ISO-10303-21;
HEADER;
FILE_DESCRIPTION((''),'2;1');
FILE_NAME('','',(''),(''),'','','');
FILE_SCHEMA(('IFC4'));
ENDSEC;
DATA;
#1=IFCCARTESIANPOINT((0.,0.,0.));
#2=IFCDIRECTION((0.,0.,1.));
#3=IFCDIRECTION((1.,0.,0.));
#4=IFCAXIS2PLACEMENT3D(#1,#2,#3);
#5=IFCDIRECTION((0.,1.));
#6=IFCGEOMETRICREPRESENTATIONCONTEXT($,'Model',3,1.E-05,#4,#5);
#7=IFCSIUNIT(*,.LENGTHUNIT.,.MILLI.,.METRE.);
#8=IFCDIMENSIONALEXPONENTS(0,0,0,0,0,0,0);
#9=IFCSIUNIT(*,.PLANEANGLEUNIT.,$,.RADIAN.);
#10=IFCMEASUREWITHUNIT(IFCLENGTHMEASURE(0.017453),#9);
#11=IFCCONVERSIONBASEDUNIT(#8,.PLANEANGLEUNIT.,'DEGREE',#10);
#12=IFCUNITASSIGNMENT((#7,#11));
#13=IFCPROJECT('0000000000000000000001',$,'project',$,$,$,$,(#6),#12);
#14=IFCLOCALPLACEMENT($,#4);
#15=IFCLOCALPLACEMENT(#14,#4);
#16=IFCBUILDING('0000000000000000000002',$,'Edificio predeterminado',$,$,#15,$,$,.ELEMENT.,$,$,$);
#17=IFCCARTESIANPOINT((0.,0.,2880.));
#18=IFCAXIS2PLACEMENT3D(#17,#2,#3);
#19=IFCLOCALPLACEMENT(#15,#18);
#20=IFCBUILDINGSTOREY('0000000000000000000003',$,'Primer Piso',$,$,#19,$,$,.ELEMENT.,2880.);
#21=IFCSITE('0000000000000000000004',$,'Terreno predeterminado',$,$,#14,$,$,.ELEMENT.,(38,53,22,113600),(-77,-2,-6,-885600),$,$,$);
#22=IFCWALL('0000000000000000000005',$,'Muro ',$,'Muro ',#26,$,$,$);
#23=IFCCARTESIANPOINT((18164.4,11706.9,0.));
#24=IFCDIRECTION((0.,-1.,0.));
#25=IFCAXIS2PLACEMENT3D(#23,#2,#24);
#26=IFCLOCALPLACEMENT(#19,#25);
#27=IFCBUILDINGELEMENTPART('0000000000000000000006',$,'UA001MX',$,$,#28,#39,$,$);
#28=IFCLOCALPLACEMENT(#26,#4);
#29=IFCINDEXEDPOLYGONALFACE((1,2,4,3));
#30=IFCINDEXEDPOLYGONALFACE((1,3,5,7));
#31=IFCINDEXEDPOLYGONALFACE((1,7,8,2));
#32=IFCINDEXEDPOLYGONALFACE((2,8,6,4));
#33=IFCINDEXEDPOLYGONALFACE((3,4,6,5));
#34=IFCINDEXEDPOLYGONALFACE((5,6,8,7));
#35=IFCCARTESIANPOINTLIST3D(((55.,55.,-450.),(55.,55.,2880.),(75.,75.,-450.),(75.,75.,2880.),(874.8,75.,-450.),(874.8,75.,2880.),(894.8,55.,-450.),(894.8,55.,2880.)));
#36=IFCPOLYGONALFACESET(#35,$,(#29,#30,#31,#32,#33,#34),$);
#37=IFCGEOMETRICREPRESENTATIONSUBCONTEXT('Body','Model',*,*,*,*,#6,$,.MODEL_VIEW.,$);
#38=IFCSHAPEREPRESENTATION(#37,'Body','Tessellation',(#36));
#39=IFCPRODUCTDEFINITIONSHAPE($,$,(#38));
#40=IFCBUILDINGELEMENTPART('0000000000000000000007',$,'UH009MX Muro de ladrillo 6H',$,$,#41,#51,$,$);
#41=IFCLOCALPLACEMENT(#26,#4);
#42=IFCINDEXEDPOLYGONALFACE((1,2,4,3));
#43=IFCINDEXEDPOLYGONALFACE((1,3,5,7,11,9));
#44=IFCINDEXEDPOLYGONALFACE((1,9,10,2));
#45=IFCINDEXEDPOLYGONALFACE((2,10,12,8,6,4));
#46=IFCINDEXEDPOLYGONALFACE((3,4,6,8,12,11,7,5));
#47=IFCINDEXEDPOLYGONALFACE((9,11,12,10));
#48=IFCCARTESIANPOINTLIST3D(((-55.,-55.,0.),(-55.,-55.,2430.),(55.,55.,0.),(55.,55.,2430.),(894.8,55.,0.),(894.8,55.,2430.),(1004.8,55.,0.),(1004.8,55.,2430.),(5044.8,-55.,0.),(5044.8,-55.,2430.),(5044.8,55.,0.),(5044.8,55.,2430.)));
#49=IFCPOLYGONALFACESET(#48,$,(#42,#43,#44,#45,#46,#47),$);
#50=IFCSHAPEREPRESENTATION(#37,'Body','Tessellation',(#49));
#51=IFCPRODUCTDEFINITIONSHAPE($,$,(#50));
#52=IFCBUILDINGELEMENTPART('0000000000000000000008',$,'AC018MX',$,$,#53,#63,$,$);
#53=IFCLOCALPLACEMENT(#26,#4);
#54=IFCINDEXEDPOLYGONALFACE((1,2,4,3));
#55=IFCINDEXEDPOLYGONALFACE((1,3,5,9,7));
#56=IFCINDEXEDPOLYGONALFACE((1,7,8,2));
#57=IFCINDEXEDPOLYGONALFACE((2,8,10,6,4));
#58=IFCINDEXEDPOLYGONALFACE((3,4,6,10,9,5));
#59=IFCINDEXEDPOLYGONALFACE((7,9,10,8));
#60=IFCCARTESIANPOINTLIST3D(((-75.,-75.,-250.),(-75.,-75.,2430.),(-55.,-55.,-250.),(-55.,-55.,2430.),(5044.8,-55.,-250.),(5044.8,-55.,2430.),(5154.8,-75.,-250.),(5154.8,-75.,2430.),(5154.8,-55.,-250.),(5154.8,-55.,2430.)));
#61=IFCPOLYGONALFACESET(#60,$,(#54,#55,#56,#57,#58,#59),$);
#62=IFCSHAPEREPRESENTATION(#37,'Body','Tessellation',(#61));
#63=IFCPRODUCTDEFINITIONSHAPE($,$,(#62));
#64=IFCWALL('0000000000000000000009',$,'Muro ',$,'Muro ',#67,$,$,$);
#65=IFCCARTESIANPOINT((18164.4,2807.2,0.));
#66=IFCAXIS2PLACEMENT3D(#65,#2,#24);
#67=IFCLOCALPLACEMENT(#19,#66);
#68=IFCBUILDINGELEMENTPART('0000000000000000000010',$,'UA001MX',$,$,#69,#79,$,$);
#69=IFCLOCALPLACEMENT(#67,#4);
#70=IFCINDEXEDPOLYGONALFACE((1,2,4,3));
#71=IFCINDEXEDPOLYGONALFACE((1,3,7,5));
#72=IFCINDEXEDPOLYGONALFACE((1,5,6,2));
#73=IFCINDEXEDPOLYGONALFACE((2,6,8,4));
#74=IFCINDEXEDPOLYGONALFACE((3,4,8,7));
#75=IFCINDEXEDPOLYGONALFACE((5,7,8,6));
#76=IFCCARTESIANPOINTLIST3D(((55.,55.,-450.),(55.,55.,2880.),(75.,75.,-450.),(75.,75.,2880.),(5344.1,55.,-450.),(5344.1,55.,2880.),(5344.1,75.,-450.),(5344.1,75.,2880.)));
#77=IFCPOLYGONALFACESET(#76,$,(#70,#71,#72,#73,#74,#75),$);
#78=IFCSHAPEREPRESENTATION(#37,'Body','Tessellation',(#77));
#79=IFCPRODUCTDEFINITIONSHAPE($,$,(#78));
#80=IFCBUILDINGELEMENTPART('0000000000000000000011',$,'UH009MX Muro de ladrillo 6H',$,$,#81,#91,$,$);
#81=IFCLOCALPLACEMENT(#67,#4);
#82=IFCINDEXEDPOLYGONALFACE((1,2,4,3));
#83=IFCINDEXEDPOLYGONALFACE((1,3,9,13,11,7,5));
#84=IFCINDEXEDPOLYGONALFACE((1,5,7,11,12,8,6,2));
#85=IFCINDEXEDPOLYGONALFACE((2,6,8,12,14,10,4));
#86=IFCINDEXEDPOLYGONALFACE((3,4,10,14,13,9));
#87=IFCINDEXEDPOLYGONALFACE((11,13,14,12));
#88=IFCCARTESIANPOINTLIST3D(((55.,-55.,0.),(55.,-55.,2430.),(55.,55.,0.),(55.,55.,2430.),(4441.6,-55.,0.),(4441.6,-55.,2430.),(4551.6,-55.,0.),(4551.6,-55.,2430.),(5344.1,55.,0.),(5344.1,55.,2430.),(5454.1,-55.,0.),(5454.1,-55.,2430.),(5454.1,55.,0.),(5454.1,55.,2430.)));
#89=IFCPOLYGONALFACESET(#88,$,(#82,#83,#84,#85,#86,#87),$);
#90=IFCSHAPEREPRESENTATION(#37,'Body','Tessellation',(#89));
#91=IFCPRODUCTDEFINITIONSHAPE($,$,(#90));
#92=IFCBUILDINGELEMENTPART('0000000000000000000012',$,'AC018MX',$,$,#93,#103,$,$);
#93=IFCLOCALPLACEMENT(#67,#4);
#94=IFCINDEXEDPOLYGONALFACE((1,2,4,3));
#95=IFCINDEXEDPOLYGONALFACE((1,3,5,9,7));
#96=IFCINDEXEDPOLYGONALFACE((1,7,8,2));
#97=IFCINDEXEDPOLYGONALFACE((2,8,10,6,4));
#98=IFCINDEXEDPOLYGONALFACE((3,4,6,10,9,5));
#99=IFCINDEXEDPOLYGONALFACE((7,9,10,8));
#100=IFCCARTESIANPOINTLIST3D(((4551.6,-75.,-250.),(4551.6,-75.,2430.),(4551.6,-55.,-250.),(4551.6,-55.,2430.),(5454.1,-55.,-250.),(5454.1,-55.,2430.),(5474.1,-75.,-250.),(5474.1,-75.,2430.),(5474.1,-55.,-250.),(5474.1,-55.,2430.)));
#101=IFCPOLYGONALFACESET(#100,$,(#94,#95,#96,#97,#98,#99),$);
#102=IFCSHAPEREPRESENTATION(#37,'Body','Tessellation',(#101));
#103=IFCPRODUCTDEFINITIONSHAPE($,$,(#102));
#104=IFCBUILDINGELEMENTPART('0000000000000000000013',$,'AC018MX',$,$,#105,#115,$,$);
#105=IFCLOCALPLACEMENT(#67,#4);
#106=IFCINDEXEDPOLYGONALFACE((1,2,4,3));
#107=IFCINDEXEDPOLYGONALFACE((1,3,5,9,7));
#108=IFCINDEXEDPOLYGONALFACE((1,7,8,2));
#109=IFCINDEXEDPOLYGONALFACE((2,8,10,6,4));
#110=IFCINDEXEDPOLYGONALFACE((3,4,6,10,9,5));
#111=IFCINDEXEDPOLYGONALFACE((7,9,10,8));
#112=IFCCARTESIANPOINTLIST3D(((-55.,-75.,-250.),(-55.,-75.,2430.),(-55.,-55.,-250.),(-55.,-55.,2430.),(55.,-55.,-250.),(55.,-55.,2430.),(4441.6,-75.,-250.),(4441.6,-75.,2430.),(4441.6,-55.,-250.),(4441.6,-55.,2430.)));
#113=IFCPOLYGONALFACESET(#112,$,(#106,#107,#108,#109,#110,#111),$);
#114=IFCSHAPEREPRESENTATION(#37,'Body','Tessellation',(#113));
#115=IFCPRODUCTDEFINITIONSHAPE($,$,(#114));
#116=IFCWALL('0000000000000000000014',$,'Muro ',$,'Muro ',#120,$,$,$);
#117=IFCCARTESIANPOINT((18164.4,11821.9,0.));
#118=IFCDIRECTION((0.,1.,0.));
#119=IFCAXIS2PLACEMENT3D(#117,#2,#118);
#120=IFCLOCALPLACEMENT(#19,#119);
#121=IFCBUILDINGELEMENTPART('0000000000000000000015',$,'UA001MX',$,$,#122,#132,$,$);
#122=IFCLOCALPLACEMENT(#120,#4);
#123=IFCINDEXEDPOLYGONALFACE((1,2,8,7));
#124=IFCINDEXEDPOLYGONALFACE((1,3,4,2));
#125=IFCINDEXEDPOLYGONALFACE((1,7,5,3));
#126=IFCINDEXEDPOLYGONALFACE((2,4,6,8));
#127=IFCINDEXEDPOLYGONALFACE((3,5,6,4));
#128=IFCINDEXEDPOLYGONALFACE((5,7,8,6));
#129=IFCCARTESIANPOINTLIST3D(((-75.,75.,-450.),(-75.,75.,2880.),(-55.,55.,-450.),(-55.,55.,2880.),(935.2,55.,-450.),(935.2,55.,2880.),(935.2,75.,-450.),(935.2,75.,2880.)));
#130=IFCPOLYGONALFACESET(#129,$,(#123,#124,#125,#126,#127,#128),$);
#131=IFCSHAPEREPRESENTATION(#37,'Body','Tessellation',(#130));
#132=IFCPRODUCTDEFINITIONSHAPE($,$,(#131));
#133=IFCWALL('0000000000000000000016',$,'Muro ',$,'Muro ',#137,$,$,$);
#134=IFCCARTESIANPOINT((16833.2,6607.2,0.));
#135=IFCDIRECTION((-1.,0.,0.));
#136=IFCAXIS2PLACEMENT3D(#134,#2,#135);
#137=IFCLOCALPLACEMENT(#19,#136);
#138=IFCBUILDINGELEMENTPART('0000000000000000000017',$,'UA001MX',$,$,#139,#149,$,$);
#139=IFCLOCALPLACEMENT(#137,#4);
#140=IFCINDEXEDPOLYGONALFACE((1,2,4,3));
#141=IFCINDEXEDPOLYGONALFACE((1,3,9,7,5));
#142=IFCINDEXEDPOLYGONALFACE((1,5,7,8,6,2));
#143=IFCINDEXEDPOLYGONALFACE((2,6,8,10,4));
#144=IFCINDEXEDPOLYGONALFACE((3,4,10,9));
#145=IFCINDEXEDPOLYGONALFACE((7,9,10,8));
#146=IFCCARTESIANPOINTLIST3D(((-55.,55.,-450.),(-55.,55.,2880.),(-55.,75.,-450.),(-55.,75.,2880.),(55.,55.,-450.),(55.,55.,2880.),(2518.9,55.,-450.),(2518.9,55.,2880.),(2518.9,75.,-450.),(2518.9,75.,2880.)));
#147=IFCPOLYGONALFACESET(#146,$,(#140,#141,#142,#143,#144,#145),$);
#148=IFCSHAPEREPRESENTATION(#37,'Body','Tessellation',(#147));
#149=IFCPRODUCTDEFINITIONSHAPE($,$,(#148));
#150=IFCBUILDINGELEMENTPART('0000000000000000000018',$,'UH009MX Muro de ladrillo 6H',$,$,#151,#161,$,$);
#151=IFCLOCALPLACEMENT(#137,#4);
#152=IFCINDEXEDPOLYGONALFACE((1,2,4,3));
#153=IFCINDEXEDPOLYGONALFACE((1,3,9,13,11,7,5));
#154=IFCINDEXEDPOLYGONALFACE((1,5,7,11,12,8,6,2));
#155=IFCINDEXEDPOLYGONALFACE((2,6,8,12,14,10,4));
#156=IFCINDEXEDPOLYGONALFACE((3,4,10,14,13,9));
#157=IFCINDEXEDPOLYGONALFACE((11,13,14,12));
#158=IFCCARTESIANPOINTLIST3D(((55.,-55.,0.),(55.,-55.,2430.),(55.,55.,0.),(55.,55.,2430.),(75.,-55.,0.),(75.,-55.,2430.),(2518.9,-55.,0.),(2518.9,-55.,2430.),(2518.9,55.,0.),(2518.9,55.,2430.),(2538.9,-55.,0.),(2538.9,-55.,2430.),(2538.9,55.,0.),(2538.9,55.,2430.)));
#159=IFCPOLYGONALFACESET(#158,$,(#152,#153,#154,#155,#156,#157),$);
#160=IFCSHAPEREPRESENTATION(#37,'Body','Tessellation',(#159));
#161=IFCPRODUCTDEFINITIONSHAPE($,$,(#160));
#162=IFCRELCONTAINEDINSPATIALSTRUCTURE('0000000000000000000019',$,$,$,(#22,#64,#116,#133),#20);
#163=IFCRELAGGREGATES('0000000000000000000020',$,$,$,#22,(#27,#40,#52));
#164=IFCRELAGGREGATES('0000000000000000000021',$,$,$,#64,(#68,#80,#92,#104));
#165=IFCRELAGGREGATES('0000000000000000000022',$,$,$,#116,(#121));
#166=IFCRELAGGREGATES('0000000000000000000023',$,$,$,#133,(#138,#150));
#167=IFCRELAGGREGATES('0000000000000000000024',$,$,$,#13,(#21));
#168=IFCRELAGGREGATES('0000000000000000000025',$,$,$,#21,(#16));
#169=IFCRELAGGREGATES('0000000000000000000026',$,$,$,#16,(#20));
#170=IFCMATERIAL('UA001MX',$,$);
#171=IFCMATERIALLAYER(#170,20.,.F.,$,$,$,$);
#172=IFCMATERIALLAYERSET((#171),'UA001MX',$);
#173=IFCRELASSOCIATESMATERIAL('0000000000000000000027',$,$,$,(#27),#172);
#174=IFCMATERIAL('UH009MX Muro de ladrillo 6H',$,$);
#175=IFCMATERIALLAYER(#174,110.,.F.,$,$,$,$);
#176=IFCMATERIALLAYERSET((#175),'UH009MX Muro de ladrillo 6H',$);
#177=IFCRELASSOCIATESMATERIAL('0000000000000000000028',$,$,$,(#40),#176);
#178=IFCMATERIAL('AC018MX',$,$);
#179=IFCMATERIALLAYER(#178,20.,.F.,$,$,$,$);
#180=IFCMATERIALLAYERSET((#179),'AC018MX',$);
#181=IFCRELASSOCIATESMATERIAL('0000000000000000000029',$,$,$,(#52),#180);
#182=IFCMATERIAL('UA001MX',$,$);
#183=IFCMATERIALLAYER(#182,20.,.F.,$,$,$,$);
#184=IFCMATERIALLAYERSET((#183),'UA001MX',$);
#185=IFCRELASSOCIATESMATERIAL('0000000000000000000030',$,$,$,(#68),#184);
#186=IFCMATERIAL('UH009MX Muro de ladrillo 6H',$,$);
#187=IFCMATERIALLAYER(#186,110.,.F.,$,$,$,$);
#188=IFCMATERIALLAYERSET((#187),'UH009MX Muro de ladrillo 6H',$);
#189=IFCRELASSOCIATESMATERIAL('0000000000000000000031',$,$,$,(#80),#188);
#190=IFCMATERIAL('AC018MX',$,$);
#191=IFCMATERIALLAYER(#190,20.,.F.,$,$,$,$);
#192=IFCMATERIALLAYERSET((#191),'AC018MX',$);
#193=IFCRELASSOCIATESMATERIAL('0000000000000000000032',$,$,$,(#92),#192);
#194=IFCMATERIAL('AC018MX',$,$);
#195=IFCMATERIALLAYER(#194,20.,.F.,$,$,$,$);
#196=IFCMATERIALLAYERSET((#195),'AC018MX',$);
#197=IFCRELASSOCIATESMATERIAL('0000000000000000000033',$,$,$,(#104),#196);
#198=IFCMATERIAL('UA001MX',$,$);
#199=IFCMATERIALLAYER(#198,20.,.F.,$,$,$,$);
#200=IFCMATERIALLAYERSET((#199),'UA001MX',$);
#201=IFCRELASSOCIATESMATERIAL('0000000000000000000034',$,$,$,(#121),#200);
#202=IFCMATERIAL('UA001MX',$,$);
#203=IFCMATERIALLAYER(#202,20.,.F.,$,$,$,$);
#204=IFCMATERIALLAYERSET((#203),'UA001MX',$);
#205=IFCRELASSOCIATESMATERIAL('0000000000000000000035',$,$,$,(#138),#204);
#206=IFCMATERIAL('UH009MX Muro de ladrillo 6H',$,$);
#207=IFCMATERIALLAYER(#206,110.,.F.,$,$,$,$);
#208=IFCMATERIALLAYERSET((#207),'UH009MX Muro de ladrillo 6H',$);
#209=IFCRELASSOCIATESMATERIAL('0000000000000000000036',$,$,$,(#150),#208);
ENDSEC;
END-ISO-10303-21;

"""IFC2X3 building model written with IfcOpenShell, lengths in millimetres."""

from ifc_helpers import new_model, entity, si_unit, converted_unit, direction, frame, origin_with_axes, place, context, subcontext, project, spatial, polyline, outline, extrude, material, layer, layer_set, layer_usage, element, aggregate, save


model = new_model("IFC2X3")

# Units and contexts
model_context = context("Model", 3, precision=1e-05, world=origin_with_axes(), true_north=direction((0.0, 1.0)))
body_context = subcontext(model_context, "Body", "Model", "MODEL_VIEW")
ifc_project = project(units=[si_unit("LENGTHUNIT", "METRE", prefix="MILLI"), converted_unit("PLANEANGLEUNIT", "DEGREE", entity("IfcLengthMeasure", 0.017453), si_unit("PLANEANGLEUNIT", "RADIAN"), dimensions=[0, 0, 0, 0, 0, 0, 0])], contexts=[model_context])

# Site, building, storey
site_placement = place(None, origin_with_axes())
site = spatial("IfcSite", under=ifc_project, at=site_placement, Name="Terreno predeterminado", CompositionType="ELEMENT", RefLatitude=(38, 53, 22, 113600), RefLongitude=(-77, -2, -6, -885600))
building_placement = place(site_placement, origin_with_axes())
building = spatial("IfcBuilding", under=site, at=building_placement, Name="Edificio predeterminado", CompositionType="ELEMENT")
storey_placement = place(building_placement, frame((0.0, 0.0, 2880.0), z_axis=(0.0, 0.0, 1.0), x_axis=(1.0, 0.0, 0.0)))
storey = spatial("IfcBuildingStorey", under=building, at=storey_placement, Name="Primer Piso", CompositionType="ELEMENT", Elevation=2880.0)

# Walls, building element parts
wall_1_placement = place(storey_placement, frame((18164.4, 11706.9, 0.0), z_axis=(0.0, 0.0, 1.0), x_axis=(0.0, -1.0, 0.0)))
wall_1 = element("IfcWall", 1, at=wall_1_placement, inside=storey, Name="Muro ", ObjectType="Muro ")
ifc_material_1 = material(Name="UA001MX")
ifc_layer_1 = layer(ifc_material_1, 20.0, ventilated=False)
ifc_layer_set_1 = layer_set([ifc_layer_1], Name="UA001MX")
ifc_layer_usage_1 = layer_usage(ifc_layer_set_1, "AXIS2", "NEGATIVE", -75.0)
building_element_part_1_placement = place(wall_1_placement, origin_with_axes())
building_element_part_1 = element("IfcBuildingElementPart", 2, at=building_element_part_1_placement, material=ifc_layer_usage_1, Name="UA001MX", context=body_context, shape_type="SweptSolid", body=[
    extrude(outline(polyline([(874.8, 75.0), (894.8, 55.0), (55.0, 55.0), (75.0, 75.0), (874.8, 75.0)])), frame((0.0, 0.0, -450.0), z_axis=(0.0, 0.0, 1.0), x_axis=(1.0, 0.0, 0.0)), (0.0, 0.0, 1.0), 3330.0),
])
ifc_material_2 = material(Name="UH009MX Muro de ladrillo 6H")
ifc_layer_2 = layer(ifc_material_2, 110.0, ventilated=False)
ifc_layer_set_2 = layer_set([ifc_layer_2], Name="UH009MX Muro de ladrillo 6H")
ifc_layer_usage_2 = layer_usage(ifc_layer_set_2, "AXIS2", "NEGATIVE", -55.0)
building_element_part_2_placement = place(wall_1_placement, origin_with_axes())
building_element_part_2 = element("IfcBuildingElementPart", 3, at=building_element_part_2_placement, material=ifc_layer_usage_2, Name="UH009MX Muro de ladrillo 6H", context=body_context, shape_type="SweptSolid", body=[
    extrude(outline(polyline([(5044.8, 55.0), (5044.8, -55.0), (-55.0, -55.0), (55.0, 55.0), (894.8, 55.0), (1004.8, 55.0), (5044.8, 55.0)])), origin_with_axes(), (0.0, 0.0, 1.0), 2430.0),
])
ifc_material_3 = material(Name="AC018MX")
ifc_layer_3 = layer(ifc_material_3, 20.0, ventilated=False)
ifc_layer_set_3 = layer_set([ifc_layer_3], Name="AC018MX")
ifc_layer_usage_3 = layer_usage(ifc_layer_set_3, "AXIS2", "NEGATIVE", 55.0)
building_element_part_3_placement = place(wall_1_placement, origin_with_axes())
building_element_part_3 = element("IfcBuildingElementPart", 4, at=building_element_part_3_placement, material=ifc_layer_usage_3, Name="AC018MX", context=body_context, shape_type="SweptSolid", body=[
    extrude(outline(polyline([(5154.8, -55.0), (5154.8, -75.0), (-75.0, -75.0), (-55.0, -55.0), (5044.8, -55.0), (5154.8, -55.0)])), frame((0.0, 0.0, -250.0), z_axis=(0.0, 0.0, 1.0), x_axis=(1.0, 0.0, 0.0)), (0.0, 0.0, 1.0), 2680.0),
])
aggregate(wall_1, [building_element_part_1, building_element_part_2, building_element_part_3])
wall_2_placement = place(storey_placement, frame((18164.4, 2807.2, 0.0), z_axis=(0.0, 0.0, 1.0), x_axis=(0.0, -1.0, 0.0)))
wall_2 = element("IfcWall", 5, at=wall_2_placement, inside=storey, Name="Muro ", ObjectType="Muro ")
ifc_material_4 = material(Name="UA001MX")
ifc_layer_4 = layer(ifc_material_4, 20.0, ventilated=False)
ifc_layer_set_4 = layer_set([ifc_layer_4], Name="UA001MX")
ifc_layer_usage_4 = layer_usage(ifc_layer_set_4, "AXIS2", "NEGATIVE", -75.0)
building_element_part_4_placement = place(wall_2_placement, origin_with_axes())
building_element_part_4 = element("IfcBuildingElementPart", 6, at=building_element_part_4_placement, material=ifc_layer_usage_4, Name="UA001MX", context=body_context, shape_type="SweptSolid", body=[
    extrude(outline(polyline([(5344.1, 75.0), (5344.1, 55.0), (55.0, 55.0), (75.0, 75.0), (5344.1, 75.0)])), frame((0.0, 0.0, -450.0), z_axis=(0.0, 0.0, 1.0), x_axis=(1.0, 0.0, 0.0)), (0.0, 0.0, 1.0), 3330.0),
])
ifc_material_5 = material(Name="UH009MX Muro de ladrillo 6H")
ifc_layer_5 = layer(ifc_material_5, 110.0, ventilated=False)
ifc_layer_set_5 = layer_set([ifc_layer_5], Name="UH009MX Muro de ladrillo 6H")
ifc_layer_usage_5 = layer_usage(ifc_layer_set_5, "AXIS2", "NEGATIVE", -55.0)
building_element_part_5_placement = place(wall_2_placement, origin_with_axes())
building_element_part_5 = element("IfcBuildingElementPart", 7, at=building_element_part_5_placement, material=ifc_layer_usage_5, Name="UH009MX Muro de ladrillo 6H", context=body_context, shape_type="SweptSolid", body=[
    extrude(outline(polyline([(5454.1, 55.0), (5454.1, -55.0), (4551.6, -55.0), (4441.6, -55.0), (55.0, -55.0), (55.0, 55.0), (5344.1, 55.0), (5454.1, 55.0)])), origin_with_axes(), (0.0, 0.0, 1.0), 2430.0),
])
ifc_material_6 = material(Name="AC018MX")
ifc_layer_6 = layer(ifc_material_6, 20.0, ventilated=False)
ifc_layer_set_6 = layer_set([ifc_layer_6], Name="AC018MX")
ifc_layer_usage_6 = layer_usage(ifc_layer_set_6, "AXIS2", "NEGATIVE", 55.0)
building_element_part_6_placement = place(wall_2_placement, origin_with_axes())
building_element_part_6 = element("IfcBuildingElementPart", 8, at=building_element_part_6_placement, material=ifc_layer_usage_6, Name="AC018MX", context=body_context, shape_type="SweptSolid", body=[
    extrude(outline(polyline([(5474.1, -55.0), (5474.1, -75.0), (4551.6, -75.0), (4551.6, -55.0), (5454.1, -55.0), (5474.1, -55.0)])), frame((0.0, 0.0, -250.0), z_axis=(0.0, 0.0, 1.0), x_axis=(1.0, 0.0, 0.0)), (0.0, 0.0, 1.0), 2680.0),
])
ifc_material_7 = material(Name="AC018MX")
ifc_layer_7 = layer(ifc_material_7, 20.0, ventilated=False)
ifc_layer_set_7 = layer_set([ifc_layer_7], Name="AC018MX")
ifc_layer_usage_7 = layer_usage(ifc_layer_set_7, "AXIS2", "NEGATIVE", 55.0)
building_element_part_7_placement = place(wall_2_placement, origin_with_axes())
building_element_part_7 = element("IfcBuildingElementPart", 9, at=building_element_part_7_placement, material=ifc_layer_usage_7, Name="AC018MX", context=body_context, shape_type="SweptSolid", body=[
    extrude(outline(polyline([(4441.6, -55.0), (4441.6, -75.0), (-55.0, -75.0), (-55.0, -55.0), (55.0, -55.0), (4441.6, -55.0)])), frame((0.0, 0.0, -250.0), z_axis=(0.0, 0.0, 1.0), x_axis=(1.0, 0.0, 0.0)), (0.0, 0.0, 1.0), 2680.0),
])
aggregate(wall_2, [building_element_part_4, building_element_part_5, building_element_part_6, building_element_part_7])

# Wall, building element part
wall_3_placement = place(storey_placement, frame((18164.4, 11821.9, 0.0), z_axis=(0.0, 0.0, 1.0), x_axis=(0.0, 1.0, 0.0)))
wall_3 = element("IfcWall", 10, at=wall_3_placement, inside=storey, Name="Muro ", ObjectType="Muro ")
ifc_material_8 = material(Name="UA001MX")
ifc_layer_8 = layer(ifc_material_8, 20.0, ventilated=False)
ifc_layer_set_8 = layer_set([ifc_layer_8], Name="UA001MX")
ifc_layer_usage_8 = layer_usage(ifc_layer_set_8, "AXIS2", "NEGATIVE", -75.0)
building_element_part_8_placement = place(wall_3_placement, origin_with_axes())
building_element_part_8 = element("IfcBuildingElementPart", 11, at=building_element_part_8_placement, material=ifc_layer_usage_8, Name="UA001MX", context=body_context, shape_type="SweptSolid", body=[
    extrude(outline(polyline([(935.2, 75.0), (935.2, 55.0), (-55.0, 55.0), (-75.0, 75.0), (935.2, 75.0)])), frame((0.0, 0.0, -450.0), z_axis=(0.0, 0.0, 1.0), x_axis=(1.0, 0.0, 0.0)), (0.0, 0.0, 1.0), 3330.0),
])
aggregate(wall_3, [building_element_part_8])

# Wall, building element parts
wall_4_placement = place(storey_placement, frame((16833.2, 6607.2, 0.0), z_axis=(0.0, 0.0, 1.0), x_axis=(-1.0, 0.0, 0.0)))
wall_4 = element("IfcWall", 12, at=wall_4_placement, inside=storey, Name="Muro ", ObjectType="Muro ")
ifc_material_9 = material(Name="UA001MX")
ifc_layer_9 = layer(ifc_material_9, 20.0, ventilated=False)
ifc_layer_set_9 = layer_set([ifc_layer_9], Name="UA001MX")
ifc_layer_usage_9 = layer_usage(ifc_layer_set_9, "AXIS2", "NEGATIVE", -75.0)
building_element_part_9_placement = place(wall_4_placement, origin_with_axes())
building_element_part_9 = element("IfcBuildingElementPart", 13, at=building_element_part_9_placement, material=ifc_layer_usage_9, Name="UA001MX", context=body_context, shape_type="SweptSolid", body=[
    extrude(outline(polyline([(2518.9, 75.0), (2518.9, 55.0), (55.0, 55.0), (-55.0, 55.0), (-55.0, 75.0), (2518.9, 75.0)])), frame((0.0, 0.0, -450.0), z_axis=(0.0, 0.0, 1.0), x_axis=(1.0, 0.0, 0.0)), (0.0, 0.0, 1.0), 3330.0),
])
ifc_material_10 = material(Name="UH009MX Muro de ladrillo 6H")
ifc_layer_10 = layer(ifc_material_10, 110.0, ventilated=False)
ifc_layer_set_10 = layer_set([ifc_layer_10], Name="UH009MX Muro de ladrillo 6H")
ifc_layer_usage_10 = layer_usage(ifc_layer_set_10, "AXIS2", "NEGATIVE", -55.0)
building_element_part_10_placement = place(wall_4_placement, origin_with_axes())
building_element_part_10 = element("IfcBuildingElementPart", 14, at=building_element_part_10_placement, material=ifc_layer_usage_10, Name="UH009MX Muro de ladrillo 6H", context=body_context, shape_type="SweptSolid", body=[
    extrude(outline(polyline([(2538.9, 55.0), (2538.9, -55.0), (2518.9, -55.0), (75.0, -55.0), (55.0, -55.0), (55.0, 55.0), (2518.9, 55.0), (2538.9, 55.0)])), origin_with_axes(), (0.0, 0.0, 1.0), 2430.0),
])
aggregate(wall_4, [building_element_part_9, building_element_part_10])

save(model, "model.ifc")
